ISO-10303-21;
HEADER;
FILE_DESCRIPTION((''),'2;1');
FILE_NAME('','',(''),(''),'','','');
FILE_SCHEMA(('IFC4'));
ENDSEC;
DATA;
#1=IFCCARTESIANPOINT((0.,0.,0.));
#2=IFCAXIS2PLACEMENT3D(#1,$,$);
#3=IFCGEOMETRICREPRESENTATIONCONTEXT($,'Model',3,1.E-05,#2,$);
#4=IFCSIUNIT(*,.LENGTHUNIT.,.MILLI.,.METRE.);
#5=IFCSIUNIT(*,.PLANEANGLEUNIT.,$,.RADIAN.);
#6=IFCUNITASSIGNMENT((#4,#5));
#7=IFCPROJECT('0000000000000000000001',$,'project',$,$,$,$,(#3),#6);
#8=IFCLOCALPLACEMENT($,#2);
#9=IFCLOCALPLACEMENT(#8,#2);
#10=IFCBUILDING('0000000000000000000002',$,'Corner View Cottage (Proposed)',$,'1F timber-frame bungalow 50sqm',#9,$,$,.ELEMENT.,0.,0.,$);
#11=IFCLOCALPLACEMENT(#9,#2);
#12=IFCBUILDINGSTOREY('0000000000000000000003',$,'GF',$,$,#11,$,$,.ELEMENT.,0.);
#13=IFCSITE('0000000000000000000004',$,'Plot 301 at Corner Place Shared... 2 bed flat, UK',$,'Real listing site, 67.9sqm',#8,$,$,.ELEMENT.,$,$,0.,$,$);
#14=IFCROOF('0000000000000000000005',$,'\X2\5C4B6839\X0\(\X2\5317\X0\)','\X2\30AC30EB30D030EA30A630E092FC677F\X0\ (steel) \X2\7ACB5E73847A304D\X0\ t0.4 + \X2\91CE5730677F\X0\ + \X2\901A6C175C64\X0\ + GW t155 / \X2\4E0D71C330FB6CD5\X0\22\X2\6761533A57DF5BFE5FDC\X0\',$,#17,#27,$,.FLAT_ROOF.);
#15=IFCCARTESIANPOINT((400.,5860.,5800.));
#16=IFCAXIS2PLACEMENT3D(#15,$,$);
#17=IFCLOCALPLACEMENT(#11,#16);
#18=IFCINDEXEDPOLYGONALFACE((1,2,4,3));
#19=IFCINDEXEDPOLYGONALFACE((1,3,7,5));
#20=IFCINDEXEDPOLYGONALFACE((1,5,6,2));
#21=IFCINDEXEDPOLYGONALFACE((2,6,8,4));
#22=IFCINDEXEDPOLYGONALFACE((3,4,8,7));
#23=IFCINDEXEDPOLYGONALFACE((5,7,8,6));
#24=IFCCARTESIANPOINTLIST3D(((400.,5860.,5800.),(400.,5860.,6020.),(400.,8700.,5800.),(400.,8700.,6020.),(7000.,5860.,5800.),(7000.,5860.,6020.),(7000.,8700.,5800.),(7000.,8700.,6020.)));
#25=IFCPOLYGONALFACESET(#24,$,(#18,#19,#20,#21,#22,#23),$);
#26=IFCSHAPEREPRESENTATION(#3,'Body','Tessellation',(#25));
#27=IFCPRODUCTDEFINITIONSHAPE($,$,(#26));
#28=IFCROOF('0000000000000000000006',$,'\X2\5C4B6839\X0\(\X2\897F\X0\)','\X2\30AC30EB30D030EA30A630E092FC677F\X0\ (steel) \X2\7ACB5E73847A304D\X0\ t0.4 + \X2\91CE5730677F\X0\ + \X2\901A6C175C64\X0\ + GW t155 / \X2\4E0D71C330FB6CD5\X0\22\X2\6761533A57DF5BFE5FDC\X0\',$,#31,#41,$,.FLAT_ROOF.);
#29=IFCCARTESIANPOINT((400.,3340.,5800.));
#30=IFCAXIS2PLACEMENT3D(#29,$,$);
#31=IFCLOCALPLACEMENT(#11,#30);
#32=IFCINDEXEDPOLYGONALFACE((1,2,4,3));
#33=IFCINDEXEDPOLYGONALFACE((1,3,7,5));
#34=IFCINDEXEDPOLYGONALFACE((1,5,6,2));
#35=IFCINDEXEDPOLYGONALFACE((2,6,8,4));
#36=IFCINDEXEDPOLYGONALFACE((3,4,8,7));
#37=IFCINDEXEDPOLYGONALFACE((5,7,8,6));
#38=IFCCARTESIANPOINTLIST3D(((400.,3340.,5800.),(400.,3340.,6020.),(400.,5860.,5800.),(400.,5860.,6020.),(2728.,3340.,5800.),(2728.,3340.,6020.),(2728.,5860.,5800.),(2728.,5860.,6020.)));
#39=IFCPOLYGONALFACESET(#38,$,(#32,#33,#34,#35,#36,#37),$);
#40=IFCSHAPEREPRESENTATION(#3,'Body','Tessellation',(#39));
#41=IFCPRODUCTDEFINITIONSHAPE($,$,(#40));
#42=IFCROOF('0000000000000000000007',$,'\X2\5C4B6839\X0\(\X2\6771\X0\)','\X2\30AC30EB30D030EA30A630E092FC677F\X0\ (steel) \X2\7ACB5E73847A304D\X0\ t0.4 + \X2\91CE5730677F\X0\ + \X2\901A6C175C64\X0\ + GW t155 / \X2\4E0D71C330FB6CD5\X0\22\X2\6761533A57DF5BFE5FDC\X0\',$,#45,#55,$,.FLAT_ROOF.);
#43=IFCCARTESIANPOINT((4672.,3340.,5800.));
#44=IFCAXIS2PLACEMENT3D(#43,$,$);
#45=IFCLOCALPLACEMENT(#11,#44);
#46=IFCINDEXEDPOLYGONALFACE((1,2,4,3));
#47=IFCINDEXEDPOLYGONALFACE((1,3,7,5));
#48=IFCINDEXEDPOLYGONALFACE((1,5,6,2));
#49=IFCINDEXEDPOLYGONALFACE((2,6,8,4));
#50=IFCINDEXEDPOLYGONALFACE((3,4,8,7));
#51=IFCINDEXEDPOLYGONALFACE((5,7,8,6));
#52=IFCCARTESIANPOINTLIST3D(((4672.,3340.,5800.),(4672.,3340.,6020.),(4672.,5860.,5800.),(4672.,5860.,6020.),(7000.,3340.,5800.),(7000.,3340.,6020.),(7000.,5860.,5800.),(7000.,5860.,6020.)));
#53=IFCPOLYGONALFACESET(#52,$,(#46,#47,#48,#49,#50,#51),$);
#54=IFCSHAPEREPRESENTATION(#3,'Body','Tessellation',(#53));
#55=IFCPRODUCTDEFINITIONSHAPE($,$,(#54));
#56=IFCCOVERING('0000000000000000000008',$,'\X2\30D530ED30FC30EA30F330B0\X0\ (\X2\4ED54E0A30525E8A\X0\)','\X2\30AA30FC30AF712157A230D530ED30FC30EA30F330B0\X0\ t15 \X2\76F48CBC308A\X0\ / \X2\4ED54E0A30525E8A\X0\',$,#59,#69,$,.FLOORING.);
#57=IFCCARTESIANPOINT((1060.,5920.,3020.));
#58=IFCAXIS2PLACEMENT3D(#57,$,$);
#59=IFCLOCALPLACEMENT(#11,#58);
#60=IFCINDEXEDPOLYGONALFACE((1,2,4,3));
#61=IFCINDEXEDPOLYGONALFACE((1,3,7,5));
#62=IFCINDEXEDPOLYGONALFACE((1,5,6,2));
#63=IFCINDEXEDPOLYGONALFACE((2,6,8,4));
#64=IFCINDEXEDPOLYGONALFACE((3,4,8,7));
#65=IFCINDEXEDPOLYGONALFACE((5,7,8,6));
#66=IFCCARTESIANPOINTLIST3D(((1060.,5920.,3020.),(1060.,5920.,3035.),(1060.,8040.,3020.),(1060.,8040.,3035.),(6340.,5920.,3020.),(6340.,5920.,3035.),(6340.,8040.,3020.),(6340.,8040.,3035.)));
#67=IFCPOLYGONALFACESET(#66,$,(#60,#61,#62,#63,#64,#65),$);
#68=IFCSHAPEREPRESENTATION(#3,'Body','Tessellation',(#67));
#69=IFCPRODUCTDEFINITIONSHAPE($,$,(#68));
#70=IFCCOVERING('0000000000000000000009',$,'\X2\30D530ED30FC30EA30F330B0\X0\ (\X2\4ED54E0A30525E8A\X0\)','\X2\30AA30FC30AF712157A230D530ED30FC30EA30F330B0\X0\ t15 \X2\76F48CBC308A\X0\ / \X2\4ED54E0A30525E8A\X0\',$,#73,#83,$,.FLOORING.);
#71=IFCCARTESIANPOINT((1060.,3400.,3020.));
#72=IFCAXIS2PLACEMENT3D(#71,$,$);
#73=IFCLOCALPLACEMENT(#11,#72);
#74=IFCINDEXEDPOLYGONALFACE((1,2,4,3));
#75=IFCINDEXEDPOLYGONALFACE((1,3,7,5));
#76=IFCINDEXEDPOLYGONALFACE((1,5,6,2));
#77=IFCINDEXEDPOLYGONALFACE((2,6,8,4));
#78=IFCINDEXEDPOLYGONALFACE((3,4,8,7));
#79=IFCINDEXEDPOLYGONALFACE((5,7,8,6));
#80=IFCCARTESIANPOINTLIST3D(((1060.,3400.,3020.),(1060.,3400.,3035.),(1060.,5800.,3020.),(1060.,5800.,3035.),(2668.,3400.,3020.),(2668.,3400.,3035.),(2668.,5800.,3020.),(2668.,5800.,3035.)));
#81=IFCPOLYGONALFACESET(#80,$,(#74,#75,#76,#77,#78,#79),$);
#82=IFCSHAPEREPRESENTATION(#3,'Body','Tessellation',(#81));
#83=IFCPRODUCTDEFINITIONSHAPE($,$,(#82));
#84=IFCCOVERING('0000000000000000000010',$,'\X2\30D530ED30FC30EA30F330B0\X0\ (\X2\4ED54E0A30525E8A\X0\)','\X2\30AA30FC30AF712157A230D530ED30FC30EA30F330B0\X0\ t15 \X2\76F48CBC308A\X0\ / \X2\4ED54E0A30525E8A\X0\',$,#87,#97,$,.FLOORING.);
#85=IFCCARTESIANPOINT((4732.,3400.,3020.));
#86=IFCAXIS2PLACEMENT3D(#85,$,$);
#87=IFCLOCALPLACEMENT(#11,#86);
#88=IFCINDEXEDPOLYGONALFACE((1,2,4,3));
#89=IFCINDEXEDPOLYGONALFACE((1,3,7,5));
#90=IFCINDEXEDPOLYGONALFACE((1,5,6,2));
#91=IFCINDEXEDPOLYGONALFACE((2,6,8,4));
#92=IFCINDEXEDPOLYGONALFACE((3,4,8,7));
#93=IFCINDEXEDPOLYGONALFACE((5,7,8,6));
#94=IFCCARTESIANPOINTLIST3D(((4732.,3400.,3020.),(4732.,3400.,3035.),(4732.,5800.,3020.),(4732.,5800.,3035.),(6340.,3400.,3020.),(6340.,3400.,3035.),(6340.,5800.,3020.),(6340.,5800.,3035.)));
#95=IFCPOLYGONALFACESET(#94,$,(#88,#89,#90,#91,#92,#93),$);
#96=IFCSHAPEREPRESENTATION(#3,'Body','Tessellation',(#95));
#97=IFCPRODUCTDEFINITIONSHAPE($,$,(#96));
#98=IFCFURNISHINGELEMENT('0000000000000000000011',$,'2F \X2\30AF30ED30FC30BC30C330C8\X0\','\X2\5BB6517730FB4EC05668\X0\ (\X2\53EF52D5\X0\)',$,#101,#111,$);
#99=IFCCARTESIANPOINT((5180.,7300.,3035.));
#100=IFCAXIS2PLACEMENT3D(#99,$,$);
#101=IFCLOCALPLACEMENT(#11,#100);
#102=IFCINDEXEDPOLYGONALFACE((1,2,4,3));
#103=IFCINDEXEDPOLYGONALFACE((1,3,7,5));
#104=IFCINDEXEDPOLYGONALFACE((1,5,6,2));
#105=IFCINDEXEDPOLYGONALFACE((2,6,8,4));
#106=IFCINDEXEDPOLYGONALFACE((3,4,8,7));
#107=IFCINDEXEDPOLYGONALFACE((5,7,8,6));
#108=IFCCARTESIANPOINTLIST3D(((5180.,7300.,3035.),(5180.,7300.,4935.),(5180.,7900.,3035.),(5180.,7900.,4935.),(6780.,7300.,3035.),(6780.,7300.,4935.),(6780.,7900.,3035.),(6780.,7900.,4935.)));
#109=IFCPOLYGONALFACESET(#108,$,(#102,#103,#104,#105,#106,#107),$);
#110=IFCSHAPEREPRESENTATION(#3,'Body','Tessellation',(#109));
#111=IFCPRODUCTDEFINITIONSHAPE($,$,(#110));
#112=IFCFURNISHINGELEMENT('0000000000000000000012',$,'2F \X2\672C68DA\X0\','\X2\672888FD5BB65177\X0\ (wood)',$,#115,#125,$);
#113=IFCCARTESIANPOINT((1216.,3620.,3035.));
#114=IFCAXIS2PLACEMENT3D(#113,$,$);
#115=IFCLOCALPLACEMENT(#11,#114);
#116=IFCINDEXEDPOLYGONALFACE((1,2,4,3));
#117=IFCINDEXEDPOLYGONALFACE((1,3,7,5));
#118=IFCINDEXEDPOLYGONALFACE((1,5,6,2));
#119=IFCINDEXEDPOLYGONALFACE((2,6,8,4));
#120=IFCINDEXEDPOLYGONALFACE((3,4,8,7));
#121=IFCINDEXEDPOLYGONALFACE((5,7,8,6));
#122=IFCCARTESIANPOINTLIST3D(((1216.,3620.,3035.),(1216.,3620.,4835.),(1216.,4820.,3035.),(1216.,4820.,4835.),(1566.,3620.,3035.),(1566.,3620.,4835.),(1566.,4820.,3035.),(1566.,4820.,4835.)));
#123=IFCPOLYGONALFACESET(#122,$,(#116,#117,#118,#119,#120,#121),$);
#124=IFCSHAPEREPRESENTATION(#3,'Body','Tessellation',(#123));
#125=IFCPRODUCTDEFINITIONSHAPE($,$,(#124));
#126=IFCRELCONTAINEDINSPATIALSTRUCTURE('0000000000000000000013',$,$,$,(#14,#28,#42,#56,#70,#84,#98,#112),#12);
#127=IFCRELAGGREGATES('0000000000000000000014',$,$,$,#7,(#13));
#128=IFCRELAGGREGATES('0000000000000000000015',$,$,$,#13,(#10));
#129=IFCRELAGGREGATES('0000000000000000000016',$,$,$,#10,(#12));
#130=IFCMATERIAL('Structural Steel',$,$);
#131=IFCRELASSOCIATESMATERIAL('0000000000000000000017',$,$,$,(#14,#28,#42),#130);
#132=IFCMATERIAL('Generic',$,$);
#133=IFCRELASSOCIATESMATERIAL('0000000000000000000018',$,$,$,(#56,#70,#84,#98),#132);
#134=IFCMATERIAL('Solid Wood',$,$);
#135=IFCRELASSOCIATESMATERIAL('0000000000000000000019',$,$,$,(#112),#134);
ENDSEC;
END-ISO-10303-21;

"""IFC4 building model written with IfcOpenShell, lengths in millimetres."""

from ifc_helpers import new_model, si_unit, frame, frame_2d, origin, place, context, project, spatial, rectangle, extrude, material, element, save


model = new_model("IFC4")

# Units and contexts
model_context = context("Model", 3, precision=1e-05, world=origin())
ifc_project = project(units=[si_unit("LENGTHUNIT", "METRE", prefix="MILLI"), si_unit("PLANEANGLEUNIT", "RADIAN")], contexts=[model_context])

# Site, building, storey
site_placement = place(None, origin())
site = spatial("IfcSite", under=ifc_project, at=site_placement, Name="Plot 301 at Corner Place Shared... 2 bed flat, UK", ObjectType="Real listing site, 67.9sqm", CompositionType="ELEMENT", RefElevation=0.0)
building_placement = place(site_placement, origin())
building = spatial("IfcBuilding", under=site, at=building_placement, Name="Corner View Cottage (Proposed)", ObjectType="1F timber-frame bungalow 50sqm", CompositionType="ELEMENT", ElevationOfRefHeight=0.0, ElevationOfTerrain=0.0)
storey_placement = place(building_placement, origin())
storey = spatial("IfcBuildingStorey", under=building, at=storey_placement, Name="GF", CompositionType="ELEMENT", Elevation=0.0)

# Shared definitions
ifc_material_1 = material(Name="Solid Wood")

# Shared definitions
ifc_material_2 = material(Name="Generic")

# Roofs
ifc_material_3 = material(Name="Structural Steel")
for number, where, name in (
    (1, (400.0, 5860.0, 5800.0), "屋根(北)"),
):
    element("IfcRoof", number, at=place(storey_placement, frame(where)), inside=storey, material=ifc_material_3, Name=name, Description="ガルバリウム鋼板 (steel) 立平葺き t0.4 + 野地板 + 通気層 + GW t155 / 不燃・法22条区域対応", PredefinedType="FLAT_ROOF", context=model_context, shape_type="SweptSolid", body=[
        extrude(rectangle(XDim=6600.0, YDim=2840.0, at=frame_2d((3300.0, 1420.0))), frame((400.0, 5860.0, 5800.0)), (0.0, 0.0, 1.0), 220.0),
    ])
roof_1_placement = place(storey_placement, frame((400.0, 3340.0, 5800.0)))
element("IfcRoof", 2, at=roof_1_placement, inside=storey, material=ifc_material_3, Name="屋根(西)", Description="ガルバリウム鋼板 (steel) 立平葺き t0.4 + 野地板 + 通気層 + GW t155 / 不燃・法22条区域対応", PredefinedType="FLAT_ROOF", context=model_context, shape_type="SweptSolid", body=[
    extrude(rectangle(XDim=2328.0, YDim=2520.0, at=frame_2d((1164.0, 1260.0))), frame((400.0, 3340.0, 5800.0)), (0.0, 0.0, 1.0), 220.0),
])
roof_2_placement = place(storey_placement, frame((4672.0, 3340.0, 5800.0)))
element("IfcRoof", 3, at=roof_2_placement, inside=storey, material=ifc_material_3, Name="屋根(東)", Description="ガルバリウム鋼板 (steel) 立平葺き t0.4 + 野地板 + 通気層 + GW t155 / 不燃・法22条区域対応", PredefinedType="FLAT_ROOF", context=model_context, shape_type="SweptSolid", body=[
    extrude(rectangle(XDim=2328.0, YDim=2520.0, at=frame_2d((1164.0, 1260.0))), frame((4672.0, 3340.0, 5800.0)), (0.0, 0.0, 1.0), 220.0),
])

# Coverings
covering_1_placement = place(storey_placement, frame((1060.0, 5920.0, 3020.0)))
element("IfcCovering", 4, at=covering_1_placement, inside=storey, material=ifc_material_2, Name="フローリング (仕上げ床)", Description="オーク無垢フローリング t15 直貼り / 仕上げ床", PredefinedType="FLOORING", context=model_context, shape_type="SweptSolid", body=[
    extrude(rectangle(XDim=5280.0, YDim=2120.0, at=frame_2d((2640.0, 1060.0))), frame((1060.0, 5920.0, 3020.0)), (0.0, 0.0, 1.0), 15.0),
])
covering_2_placement = place(storey_placement, frame((1060.0, 3400.0, 3020.0)))
element("IfcCovering", 5, at=covering_2_placement, inside=storey, material=ifc_material_2, Name="フローリング (仕上げ床)", Description="オーク無垢フローリング t15 直貼り / 仕上げ床", PredefinedType="FLOORING", context=model_context, shape_type="SweptSolid", body=[
    extrude(rectangle(XDim=1608.0, YDim=2400.0, at=frame_2d((804.0, 1200.0))), frame((1060.0, 3400.0, 3020.0)), (0.0, 0.0, 1.0), 15.0),
])
covering_3_placement = place(storey_placement, frame((4732.0, 3400.0, 3020.0)))
element("IfcCovering", 6, at=covering_3_placement, inside=storey, material=ifc_material_2, Name="フローリング (仕上げ床)", Description="オーク無垢フローリング t15 直貼り / 仕上げ床", PredefinedType="FLOORING", context=model_context, shape_type="SweptSolid", body=[
    extrude(rectangle(XDim=1608.0, YDim=2400.0, at=frame_2d((804.0, 1200.0))), frame((4732.0, 3400.0, 3020.0)), (0.0, 0.0, 1.0), 15.0),
])

# Furnishing elements
furnishing_1_placement = place(storey_placement, frame((5180.0, 7300.0, 3035.0)))
element("IfcFurnishingElement", 7, at=furnishing_1_placement, inside=storey, material=ifc_material_2, Name="2F クローゼット", Description="家具・什器 (可動)", context=model_context, shape_type="SweptSolid", body=[
    extrude(rectangle(XDim=1600.0, YDim=600.0, at=frame_2d((800.0, 300.0))), frame((5180.0, 7300.0, 3035.0)), (0.0, 0.0, 1.0), 1900.0),
])
furnishing_2_placement = place(storey_placement, frame((1216.0, 3620.0, 3035.0)))
element("IfcFurnishingElement", 8, at=furnishing_2_placement, inside=storey, material=ifc_material_1, Name="2F 本棚", Description="木製家具 (wood)", context=model_context, shape_type="SweptSolid", body=[
    extrude(rectangle(XDim=350.0, YDim=1200.0, at=frame_2d((175.0, 600.0))), frame((1216.0, 3620.0, 3035.0)), (0.0, 0.0, 1.0), 1800.0),
])

save(model, "model.ifc")
